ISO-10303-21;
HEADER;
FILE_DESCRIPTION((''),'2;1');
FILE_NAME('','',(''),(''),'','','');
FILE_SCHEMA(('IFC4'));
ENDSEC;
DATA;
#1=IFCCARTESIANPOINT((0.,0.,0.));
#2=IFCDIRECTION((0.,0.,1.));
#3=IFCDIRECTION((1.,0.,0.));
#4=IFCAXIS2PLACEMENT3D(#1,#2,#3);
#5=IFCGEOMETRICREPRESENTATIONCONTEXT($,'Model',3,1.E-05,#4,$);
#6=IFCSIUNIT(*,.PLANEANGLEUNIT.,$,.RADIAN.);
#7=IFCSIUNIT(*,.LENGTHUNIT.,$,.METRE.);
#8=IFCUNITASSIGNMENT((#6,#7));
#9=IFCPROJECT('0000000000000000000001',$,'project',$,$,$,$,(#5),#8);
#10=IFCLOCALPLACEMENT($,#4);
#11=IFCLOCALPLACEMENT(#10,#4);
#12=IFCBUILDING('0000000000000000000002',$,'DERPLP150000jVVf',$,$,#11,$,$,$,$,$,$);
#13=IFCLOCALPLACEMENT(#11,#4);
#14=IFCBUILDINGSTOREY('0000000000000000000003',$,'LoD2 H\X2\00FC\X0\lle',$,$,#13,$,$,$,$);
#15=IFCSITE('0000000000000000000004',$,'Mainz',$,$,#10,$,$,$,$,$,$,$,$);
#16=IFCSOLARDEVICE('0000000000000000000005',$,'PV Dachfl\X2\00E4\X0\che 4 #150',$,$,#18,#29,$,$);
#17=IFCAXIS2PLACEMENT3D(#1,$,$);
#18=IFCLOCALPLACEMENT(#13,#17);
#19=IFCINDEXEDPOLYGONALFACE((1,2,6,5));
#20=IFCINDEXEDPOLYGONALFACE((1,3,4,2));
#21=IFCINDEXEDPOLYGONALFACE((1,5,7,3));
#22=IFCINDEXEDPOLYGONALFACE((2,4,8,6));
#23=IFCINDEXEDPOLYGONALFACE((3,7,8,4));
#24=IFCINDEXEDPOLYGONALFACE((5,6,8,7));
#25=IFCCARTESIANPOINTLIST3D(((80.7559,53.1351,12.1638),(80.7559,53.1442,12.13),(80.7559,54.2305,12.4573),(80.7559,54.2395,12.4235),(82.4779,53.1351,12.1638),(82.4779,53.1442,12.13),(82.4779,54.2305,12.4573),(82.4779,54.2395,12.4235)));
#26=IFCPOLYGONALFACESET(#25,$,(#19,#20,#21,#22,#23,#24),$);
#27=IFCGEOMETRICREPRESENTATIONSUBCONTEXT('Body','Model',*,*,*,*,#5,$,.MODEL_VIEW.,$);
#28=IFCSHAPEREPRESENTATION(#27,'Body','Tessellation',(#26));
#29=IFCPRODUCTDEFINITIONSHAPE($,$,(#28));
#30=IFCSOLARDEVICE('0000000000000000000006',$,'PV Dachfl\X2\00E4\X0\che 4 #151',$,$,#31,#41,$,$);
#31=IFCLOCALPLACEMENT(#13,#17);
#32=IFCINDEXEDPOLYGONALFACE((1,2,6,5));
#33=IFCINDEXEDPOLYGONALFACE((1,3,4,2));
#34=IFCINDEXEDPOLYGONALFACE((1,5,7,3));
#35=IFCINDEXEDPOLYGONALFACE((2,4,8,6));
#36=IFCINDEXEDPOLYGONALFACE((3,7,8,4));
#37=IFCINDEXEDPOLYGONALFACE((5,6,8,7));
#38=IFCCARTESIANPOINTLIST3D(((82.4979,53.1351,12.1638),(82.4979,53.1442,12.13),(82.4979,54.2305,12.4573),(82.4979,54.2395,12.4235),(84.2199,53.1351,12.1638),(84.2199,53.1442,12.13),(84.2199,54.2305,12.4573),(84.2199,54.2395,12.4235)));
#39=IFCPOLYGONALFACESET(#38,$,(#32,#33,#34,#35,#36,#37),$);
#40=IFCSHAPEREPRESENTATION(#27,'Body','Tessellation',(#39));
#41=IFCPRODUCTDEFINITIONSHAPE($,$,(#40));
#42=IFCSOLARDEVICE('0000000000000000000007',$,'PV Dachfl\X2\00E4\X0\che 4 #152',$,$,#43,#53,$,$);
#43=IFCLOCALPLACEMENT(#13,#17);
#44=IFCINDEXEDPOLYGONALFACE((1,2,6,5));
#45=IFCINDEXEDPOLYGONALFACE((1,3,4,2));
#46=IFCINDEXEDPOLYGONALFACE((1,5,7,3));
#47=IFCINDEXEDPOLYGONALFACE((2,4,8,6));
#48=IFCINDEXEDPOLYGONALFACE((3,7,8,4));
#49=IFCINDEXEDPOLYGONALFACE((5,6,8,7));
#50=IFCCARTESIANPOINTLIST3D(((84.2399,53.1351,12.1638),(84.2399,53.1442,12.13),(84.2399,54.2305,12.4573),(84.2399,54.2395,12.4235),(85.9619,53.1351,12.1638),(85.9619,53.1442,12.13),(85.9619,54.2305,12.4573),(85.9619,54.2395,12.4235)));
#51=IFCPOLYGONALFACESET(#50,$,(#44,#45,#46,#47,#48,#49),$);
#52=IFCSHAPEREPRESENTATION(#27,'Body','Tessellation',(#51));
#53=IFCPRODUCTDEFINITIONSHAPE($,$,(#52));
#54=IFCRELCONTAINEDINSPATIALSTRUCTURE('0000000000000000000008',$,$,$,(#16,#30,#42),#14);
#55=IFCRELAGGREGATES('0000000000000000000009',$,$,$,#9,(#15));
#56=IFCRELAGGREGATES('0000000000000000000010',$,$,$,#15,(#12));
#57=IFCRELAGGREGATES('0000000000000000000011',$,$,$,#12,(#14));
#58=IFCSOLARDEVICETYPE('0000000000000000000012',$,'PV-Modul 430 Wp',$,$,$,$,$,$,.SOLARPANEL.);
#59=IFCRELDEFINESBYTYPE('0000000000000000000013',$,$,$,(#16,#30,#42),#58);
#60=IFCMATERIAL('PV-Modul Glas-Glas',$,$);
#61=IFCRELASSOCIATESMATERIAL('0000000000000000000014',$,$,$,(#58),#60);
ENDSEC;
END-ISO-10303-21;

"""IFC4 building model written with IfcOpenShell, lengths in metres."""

from ifc_helpers import new_model, si_unit, frame, frame_2d, origin, origin_with_axes, place, context, subcontext, project, spatial, rectangle, extrude, source, transform, mapped, material, type_object, type_shapes, element, save


model = new_model("IFC4")

# Units and contexts
model_context = context("Model", 3, precision=1e-05, world=origin_with_axes())
body_context = subcontext(model_context, "Body", "Model", "MODEL_VIEW")
ifc_project = project(units=[si_unit("PLANEANGLEUNIT", "RADIAN"), si_unit("LENGTHUNIT", "METRE")], contexts=[model_context])

# Site, building, storey
site_placement = place(None, origin_with_axes())
site = spatial("IfcSite", under=ifc_project, at=site_placement, Name="Mainz")
building_placement = place(site_placement, origin_with_axes())
building = spatial("IfcBuilding", under=site, at=building_placement, Name="DERPLP150000jVVf")
storey_placement = place(building_placement, origin_with_axes())
storey = spatial("IfcBuildingStorey", under=building, at=storey_placement, Name="LoD2 Hülle")

# Solar devices
ifc_material = material(Name="PV-Modul Glas-Glas")
solar_device_type = type_object("IfcSolarDeviceType", Name="PV-Modul 430 Wp", PredefinedType="SOLARPANEL", material=ifc_material)
shared_shape = source(origin_with_axes(), body_context, "Body", "SweptSolid", [
    extrude(rectangle(XDim=1.722, YDim=1.134, at=frame_2d((0.861, 0.567))), origin(), (0.0, 0.0, 1.0), 0.035),
])
type_shapes(solar_device_type, [shared_shape])
for number, where, z_axis, x_axis, name in (
    (1, (80.7559, 53.1442, 12.13), (0.0, -0.258819, 0.965926), (1.0, 0.0, 0.0), "PV Dachfläche 4 #150"),
    (2, (82.4979, 53.1442, 12.13), (0.0, -0.258819, 0.965926), (1.0, 0.0, 0.0), "PV Dachfläche 4 #151"),
    (3, (84.2399, 53.1442, 12.13), (0.0, -0.258819, 0.965926), (1.0, 0.0, 0.0), "PV Dachfläche 4 #152"),
):
    element("IfcSolarDevice", number, at=place(storey_placement, frame(where, z_axis=z_axis, x_axis=x_axis)), inside=storey, type_object=solar_device_type, Name=name, context=body_context, shape_type="MappedRepresentation", body=[
        mapped(shared_shape, transform((0.0, 0.0, 0.0), x_axis=(1.0, 0.0, 0.0), y_axis=(0.0, 1.0, 0.0), z_axis=(0.0, 0.0, 1.0), scale=1.0)),
    ])

save(model, "model.ifc")
